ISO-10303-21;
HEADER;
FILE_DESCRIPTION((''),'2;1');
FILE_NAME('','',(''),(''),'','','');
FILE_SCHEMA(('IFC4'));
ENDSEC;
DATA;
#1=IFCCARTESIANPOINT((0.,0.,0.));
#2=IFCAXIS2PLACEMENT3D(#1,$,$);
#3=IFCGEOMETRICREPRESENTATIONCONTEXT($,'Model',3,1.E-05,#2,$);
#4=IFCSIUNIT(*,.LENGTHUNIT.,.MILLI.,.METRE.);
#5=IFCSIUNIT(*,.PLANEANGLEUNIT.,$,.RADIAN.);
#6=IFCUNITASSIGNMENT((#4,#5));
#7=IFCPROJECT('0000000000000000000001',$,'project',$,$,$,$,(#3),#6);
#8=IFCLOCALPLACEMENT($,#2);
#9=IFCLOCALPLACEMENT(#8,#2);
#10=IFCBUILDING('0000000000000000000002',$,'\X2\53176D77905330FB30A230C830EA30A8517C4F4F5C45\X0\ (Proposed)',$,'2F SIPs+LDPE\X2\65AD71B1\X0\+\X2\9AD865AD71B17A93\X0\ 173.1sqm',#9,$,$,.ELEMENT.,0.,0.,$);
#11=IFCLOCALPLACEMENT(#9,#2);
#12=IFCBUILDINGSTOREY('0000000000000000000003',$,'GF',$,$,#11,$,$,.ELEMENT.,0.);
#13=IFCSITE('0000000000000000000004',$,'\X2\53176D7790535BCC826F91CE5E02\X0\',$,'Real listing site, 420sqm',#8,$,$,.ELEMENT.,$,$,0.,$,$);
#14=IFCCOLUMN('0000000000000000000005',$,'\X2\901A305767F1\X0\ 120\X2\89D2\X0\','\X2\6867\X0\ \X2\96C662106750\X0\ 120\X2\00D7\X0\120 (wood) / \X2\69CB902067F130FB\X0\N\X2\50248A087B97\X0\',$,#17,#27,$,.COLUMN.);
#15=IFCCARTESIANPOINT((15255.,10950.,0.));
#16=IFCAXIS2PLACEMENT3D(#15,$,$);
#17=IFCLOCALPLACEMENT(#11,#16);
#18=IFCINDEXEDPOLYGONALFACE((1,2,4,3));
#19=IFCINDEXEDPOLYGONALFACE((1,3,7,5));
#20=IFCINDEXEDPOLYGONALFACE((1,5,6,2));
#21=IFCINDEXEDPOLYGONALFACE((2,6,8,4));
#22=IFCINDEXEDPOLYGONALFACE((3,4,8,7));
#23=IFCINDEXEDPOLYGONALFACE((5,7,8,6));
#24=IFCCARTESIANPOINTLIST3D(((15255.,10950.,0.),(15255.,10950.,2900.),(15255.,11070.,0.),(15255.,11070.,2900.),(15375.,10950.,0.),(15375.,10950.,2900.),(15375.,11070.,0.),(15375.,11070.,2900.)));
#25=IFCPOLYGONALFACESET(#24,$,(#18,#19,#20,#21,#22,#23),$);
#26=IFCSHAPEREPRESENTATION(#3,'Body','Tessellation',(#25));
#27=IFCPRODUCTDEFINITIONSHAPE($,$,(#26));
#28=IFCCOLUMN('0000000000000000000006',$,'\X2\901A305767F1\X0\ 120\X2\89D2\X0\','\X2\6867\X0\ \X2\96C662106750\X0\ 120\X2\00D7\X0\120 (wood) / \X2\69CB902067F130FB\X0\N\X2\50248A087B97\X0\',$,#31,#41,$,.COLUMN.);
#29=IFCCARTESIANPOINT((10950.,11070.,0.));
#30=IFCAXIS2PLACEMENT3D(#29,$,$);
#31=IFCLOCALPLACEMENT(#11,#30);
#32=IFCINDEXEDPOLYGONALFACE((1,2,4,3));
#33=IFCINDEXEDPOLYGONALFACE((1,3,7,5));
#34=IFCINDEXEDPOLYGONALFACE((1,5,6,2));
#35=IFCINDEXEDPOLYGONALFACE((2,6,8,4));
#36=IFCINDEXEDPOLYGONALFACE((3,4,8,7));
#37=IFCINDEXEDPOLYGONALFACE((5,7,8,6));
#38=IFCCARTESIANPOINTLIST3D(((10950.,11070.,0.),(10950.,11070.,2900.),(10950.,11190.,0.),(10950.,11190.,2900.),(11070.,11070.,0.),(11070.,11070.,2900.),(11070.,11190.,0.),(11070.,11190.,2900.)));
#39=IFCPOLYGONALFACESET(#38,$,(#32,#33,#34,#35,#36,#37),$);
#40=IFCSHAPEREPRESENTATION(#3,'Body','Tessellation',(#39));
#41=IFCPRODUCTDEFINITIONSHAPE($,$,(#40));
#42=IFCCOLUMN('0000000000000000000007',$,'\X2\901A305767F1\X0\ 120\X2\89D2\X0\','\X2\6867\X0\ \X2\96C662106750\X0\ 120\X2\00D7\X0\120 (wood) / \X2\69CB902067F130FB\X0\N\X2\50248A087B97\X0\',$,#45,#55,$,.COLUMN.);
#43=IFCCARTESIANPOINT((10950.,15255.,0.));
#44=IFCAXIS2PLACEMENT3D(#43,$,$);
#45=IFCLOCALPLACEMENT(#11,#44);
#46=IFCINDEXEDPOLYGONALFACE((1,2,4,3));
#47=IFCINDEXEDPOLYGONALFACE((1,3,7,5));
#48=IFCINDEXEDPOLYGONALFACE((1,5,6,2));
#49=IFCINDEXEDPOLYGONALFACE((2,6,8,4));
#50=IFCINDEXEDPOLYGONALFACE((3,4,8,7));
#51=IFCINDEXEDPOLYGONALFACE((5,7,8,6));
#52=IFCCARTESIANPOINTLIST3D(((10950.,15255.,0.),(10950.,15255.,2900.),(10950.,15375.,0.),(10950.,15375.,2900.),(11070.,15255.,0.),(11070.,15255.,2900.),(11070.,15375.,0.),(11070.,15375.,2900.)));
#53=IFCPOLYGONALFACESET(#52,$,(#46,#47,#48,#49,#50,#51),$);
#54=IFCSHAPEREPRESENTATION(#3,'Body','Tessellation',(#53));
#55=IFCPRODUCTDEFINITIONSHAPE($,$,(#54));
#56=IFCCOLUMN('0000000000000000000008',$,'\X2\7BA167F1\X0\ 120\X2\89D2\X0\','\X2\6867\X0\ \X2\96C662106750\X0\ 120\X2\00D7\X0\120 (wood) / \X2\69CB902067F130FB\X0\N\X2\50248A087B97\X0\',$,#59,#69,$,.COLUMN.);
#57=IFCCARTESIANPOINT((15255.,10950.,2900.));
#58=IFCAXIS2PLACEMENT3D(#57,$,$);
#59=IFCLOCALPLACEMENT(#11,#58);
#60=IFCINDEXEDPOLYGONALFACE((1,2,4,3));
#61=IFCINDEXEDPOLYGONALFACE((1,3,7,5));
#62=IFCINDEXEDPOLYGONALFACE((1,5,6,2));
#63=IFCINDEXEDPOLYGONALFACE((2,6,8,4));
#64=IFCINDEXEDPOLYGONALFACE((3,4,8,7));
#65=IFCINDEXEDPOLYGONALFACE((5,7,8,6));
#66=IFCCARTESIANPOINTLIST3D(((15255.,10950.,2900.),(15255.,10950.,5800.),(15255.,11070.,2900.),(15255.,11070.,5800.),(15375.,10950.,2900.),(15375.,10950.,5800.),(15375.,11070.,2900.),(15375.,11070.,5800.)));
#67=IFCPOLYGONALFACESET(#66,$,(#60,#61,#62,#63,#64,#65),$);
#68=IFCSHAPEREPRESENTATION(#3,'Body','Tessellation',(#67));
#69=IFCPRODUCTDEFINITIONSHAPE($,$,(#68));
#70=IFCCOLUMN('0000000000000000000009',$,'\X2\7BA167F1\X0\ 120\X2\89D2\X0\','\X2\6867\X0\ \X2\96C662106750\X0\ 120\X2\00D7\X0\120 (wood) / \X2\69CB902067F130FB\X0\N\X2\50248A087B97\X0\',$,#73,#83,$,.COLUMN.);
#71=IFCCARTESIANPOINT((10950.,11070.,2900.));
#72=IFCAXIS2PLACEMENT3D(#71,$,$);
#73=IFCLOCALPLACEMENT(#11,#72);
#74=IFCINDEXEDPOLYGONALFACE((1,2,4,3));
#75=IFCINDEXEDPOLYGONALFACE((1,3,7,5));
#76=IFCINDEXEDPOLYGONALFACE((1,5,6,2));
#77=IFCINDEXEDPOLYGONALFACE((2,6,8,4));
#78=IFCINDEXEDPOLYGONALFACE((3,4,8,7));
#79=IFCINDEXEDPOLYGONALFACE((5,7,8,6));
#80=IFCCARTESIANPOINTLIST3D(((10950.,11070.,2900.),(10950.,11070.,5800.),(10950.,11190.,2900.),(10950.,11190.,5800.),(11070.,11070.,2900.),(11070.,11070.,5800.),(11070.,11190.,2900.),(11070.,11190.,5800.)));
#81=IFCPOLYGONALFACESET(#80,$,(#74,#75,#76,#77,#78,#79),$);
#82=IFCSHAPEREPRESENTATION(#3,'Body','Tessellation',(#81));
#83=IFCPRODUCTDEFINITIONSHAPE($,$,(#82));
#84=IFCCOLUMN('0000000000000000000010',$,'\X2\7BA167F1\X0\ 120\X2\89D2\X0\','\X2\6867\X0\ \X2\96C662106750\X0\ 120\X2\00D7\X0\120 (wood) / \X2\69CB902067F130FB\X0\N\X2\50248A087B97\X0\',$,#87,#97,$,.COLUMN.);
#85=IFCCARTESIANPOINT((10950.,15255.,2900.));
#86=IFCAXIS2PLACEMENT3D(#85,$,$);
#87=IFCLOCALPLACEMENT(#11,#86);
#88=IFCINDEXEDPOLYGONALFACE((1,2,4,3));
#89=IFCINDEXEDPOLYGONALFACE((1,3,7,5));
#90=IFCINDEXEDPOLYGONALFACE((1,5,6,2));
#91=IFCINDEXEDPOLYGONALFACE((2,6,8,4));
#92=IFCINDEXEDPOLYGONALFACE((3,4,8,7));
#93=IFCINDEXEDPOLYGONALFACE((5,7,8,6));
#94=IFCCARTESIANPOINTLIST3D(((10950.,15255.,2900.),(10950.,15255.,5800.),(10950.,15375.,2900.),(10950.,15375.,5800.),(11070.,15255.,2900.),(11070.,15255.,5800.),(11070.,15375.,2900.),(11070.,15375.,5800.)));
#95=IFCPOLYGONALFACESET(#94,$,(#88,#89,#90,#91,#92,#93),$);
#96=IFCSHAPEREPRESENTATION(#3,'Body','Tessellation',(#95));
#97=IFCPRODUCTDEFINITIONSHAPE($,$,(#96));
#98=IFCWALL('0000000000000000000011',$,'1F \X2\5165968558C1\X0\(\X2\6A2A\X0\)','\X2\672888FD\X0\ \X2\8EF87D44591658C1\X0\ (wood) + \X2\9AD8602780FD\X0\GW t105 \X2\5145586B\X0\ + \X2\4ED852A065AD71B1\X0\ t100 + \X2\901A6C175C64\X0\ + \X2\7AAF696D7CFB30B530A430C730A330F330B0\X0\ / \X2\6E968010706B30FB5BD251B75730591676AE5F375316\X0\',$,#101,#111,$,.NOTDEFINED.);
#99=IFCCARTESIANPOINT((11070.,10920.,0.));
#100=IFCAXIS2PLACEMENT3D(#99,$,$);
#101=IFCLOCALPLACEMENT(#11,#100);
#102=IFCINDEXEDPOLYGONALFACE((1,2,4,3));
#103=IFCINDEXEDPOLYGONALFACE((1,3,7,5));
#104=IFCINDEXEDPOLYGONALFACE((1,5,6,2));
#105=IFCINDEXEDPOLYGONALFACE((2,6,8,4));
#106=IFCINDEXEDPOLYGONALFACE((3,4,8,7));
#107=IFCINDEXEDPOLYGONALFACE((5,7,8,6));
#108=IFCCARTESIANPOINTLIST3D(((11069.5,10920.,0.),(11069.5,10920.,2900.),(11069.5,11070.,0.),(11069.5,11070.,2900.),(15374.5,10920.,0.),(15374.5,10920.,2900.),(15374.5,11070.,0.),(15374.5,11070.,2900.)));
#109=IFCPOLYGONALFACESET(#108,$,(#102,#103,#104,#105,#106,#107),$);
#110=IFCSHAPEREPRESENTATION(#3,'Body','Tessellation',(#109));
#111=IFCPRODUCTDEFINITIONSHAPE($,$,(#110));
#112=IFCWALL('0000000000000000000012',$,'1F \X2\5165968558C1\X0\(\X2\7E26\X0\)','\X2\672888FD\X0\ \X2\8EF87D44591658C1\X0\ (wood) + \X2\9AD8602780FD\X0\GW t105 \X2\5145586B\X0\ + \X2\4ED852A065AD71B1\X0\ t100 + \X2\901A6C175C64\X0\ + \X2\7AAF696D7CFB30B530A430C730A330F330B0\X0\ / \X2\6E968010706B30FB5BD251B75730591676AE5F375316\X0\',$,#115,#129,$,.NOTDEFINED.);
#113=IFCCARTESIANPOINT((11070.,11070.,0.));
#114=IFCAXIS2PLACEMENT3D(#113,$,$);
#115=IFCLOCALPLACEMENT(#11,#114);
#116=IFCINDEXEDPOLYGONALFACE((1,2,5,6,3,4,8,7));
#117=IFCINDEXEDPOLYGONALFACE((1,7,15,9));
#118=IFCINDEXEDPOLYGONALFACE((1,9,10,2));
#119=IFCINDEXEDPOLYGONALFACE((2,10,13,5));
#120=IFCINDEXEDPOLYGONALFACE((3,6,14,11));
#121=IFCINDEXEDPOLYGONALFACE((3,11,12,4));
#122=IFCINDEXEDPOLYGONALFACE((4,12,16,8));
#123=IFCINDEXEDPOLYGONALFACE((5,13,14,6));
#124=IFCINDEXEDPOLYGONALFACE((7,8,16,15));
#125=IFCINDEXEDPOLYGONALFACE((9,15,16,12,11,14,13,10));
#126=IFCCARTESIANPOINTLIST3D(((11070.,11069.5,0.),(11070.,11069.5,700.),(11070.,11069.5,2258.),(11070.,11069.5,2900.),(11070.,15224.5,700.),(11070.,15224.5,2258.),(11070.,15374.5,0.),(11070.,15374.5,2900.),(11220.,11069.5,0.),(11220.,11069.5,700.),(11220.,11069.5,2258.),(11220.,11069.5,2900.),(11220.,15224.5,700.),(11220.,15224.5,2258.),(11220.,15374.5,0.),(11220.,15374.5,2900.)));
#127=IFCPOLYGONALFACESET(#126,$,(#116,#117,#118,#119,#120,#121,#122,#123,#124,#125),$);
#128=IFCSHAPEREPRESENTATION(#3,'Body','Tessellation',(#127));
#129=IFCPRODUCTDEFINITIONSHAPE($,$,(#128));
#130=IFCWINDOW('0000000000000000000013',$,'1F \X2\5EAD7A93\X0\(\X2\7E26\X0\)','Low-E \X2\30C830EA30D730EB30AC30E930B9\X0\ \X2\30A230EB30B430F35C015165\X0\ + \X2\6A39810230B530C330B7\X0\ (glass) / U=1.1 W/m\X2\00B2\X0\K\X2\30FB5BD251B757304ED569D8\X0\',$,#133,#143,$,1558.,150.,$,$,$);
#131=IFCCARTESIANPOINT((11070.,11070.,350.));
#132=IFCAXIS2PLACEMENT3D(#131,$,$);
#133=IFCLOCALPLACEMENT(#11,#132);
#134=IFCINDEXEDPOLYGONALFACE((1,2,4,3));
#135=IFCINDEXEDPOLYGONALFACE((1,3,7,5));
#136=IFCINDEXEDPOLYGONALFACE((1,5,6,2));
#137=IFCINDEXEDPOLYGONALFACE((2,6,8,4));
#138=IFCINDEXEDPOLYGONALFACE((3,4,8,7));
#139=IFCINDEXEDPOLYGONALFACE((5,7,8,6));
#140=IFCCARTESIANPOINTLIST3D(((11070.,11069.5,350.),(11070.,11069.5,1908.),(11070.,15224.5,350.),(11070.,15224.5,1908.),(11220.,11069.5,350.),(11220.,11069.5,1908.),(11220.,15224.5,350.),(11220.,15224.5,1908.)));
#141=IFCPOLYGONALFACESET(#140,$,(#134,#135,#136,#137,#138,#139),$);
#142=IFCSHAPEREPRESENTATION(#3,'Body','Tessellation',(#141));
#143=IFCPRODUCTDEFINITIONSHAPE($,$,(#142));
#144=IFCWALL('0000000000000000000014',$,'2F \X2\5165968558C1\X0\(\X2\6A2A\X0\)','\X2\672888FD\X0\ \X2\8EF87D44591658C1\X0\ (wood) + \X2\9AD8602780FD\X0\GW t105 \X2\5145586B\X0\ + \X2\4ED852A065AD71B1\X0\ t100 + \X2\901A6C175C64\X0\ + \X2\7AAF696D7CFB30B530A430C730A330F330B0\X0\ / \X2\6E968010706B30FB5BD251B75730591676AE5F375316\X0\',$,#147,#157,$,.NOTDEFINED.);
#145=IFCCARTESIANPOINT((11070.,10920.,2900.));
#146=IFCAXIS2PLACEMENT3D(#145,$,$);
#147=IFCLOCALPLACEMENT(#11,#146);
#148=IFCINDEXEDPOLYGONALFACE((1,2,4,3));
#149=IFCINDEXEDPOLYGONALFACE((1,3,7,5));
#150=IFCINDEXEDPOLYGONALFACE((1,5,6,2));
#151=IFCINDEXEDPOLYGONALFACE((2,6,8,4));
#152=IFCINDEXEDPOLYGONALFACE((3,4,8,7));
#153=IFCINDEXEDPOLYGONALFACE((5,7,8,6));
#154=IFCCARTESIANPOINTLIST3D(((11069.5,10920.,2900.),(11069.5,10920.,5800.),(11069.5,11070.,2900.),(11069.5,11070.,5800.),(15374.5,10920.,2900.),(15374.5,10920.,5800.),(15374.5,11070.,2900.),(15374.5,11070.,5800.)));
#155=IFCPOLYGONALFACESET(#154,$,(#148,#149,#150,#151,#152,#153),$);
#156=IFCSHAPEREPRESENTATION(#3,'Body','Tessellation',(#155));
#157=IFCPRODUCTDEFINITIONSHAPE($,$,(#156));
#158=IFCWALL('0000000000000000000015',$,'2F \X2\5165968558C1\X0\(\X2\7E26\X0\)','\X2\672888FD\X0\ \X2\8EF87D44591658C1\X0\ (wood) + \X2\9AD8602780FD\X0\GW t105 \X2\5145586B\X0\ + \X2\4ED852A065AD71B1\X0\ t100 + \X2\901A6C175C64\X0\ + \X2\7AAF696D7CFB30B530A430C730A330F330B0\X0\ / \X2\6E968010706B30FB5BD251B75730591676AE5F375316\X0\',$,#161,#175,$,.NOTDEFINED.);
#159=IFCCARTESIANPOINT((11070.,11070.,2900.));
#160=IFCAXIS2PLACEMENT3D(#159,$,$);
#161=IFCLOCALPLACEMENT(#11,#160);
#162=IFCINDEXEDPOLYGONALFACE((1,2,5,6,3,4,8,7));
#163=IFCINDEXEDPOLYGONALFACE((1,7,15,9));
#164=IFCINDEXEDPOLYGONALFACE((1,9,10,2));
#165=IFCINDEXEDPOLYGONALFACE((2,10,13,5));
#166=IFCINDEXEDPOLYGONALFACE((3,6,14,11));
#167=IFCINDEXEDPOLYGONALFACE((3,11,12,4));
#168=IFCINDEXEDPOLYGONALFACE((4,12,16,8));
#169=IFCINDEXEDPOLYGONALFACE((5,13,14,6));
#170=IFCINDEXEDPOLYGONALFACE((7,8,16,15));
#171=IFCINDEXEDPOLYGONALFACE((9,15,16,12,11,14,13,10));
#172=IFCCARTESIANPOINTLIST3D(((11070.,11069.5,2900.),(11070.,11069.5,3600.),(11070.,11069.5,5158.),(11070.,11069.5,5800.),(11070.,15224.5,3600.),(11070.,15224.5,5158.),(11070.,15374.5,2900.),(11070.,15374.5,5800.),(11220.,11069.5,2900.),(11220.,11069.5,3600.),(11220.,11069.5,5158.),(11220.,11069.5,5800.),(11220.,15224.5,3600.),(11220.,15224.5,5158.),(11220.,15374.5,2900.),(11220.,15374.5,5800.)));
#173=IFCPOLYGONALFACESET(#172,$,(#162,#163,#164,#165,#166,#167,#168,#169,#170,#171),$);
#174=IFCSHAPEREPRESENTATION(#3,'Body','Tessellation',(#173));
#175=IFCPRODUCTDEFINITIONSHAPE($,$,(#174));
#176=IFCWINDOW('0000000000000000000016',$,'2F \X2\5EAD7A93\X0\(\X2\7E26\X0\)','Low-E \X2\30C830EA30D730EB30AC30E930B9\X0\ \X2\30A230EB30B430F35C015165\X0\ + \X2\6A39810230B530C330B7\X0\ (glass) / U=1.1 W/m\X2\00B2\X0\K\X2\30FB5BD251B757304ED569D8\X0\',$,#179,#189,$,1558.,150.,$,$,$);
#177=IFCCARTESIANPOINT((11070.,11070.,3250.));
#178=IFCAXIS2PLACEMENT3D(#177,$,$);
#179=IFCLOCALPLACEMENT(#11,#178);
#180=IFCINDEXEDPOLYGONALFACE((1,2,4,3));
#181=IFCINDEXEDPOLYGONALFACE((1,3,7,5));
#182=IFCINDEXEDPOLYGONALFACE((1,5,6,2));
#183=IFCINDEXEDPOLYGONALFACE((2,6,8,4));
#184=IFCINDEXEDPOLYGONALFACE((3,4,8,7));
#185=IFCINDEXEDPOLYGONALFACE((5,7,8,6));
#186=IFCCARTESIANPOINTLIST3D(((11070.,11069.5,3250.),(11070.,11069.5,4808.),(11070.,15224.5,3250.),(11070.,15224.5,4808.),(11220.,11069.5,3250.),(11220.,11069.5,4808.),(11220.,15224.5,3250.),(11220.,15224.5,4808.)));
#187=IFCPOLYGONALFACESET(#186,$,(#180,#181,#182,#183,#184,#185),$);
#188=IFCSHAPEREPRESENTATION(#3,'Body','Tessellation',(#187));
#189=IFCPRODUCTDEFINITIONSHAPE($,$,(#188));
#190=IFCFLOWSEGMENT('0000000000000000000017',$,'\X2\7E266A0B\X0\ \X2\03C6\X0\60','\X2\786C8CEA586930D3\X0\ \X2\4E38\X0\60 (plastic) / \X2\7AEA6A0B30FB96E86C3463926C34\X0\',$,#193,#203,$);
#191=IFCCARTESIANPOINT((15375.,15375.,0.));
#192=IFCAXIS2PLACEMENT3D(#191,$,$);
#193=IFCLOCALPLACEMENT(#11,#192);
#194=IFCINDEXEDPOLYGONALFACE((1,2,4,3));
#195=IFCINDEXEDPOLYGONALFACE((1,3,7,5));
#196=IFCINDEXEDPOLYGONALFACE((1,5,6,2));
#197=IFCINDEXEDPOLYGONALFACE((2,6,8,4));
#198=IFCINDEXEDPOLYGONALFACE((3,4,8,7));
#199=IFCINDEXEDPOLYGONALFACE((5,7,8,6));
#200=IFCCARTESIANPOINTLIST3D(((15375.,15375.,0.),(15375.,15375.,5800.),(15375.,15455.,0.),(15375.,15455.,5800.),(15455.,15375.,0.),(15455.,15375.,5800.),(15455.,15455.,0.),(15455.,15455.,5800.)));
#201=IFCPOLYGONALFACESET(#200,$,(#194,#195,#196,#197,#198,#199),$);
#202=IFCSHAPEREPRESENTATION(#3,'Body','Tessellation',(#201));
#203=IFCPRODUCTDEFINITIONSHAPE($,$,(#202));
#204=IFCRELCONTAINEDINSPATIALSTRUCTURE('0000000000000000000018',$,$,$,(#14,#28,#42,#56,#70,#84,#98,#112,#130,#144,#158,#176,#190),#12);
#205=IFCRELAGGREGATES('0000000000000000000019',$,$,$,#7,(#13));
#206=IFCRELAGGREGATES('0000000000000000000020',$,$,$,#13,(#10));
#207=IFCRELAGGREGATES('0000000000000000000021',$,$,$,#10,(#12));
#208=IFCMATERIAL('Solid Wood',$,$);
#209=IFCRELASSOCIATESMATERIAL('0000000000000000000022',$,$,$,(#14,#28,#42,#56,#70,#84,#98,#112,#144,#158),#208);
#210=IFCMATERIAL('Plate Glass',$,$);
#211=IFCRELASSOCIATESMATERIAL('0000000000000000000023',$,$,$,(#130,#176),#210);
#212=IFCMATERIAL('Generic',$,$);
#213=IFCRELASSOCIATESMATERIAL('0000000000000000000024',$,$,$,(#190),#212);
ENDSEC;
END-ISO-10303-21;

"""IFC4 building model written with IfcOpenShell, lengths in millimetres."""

from ifc_helpers import new_model, si_unit, frame, frame_2d, origin, place, context, project, spatial, rectangle, extrude, material, element, fill, save


model = new_model("IFC4")

# Units and contexts
model_context = context("Model", 3, precision=1e-05, world=origin())
ifc_project = project(units=[si_unit("LENGTHUNIT", "METRE", prefix="MILLI"), si_unit("PLANEANGLEUNIT", "RADIAN")], contexts=[model_context])

# Site, building, storey
site_placement = place(None, origin())
site = spatial("IfcSite", under=ifc_project, at=site_placement, Name="北海道富良野市", ObjectType="Real listing site, 420sqm", CompositionType="ELEMENT", RefElevation=0.0)
building_placement = place(site_placement, origin())
building = spatial("IfcBuilding", under=site, at=building_placement, Name="北海道・アトリエ兼住居 (Proposed)", ObjectType="2F SIPs+LDPE断熱+高断熱窓 173.1sqm", CompositionType="ELEMENT", ElevationOfRefHeight=0.0, ElevationOfTerrain=0.0)
storey_placement = place(building_placement, origin())
storey = spatial("IfcBuildingStorey", under=building, at=storey_placement, Name="GF", CompositionType="ELEMENT", Elevation=0.0)

# Columns
ifc_material_1 = material(Name="Solid Wood")
column_1_placement = place(storey_placement, frame((15255.0, 10950.0, 0.0)))
element("IfcColumn", 1, at=column_1_placement, inside=storey, material=ifc_material_1, Name="通し柱 120角", Description="桧 集成材 120×120 (wood) / 構造柱・N値計算", PredefinedType="COLUMN", context=model_context, shape_type="SweptSolid", body=[
    extrude(rectangle(XDim=120.0, YDim=120.0, at=frame_2d((60.0, 60.0))), frame((15255.0, 10950.0, 0.0)), (0.0, 0.0, 1.0), 2900.0),
])
column_2_placement = place(storey_placement, frame((10950.0, 11070.0, 0.0)))
element("IfcColumn", 2, at=column_2_placement, inside=storey, material=ifc_material_1, Name="通し柱 120角", Description="桧 集成材 120×120 (wood) / 構造柱・N値計算", PredefinedType="COLUMN", context=model_context, shape_type="SweptSolid", body=[
    extrude(rectangle(XDim=120.0, YDim=120.0, at=frame_2d((60.0, 60.0))), frame((10950.0, 11070.0, 0.0)), (0.0, 0.0, 1.0), 2900.0),
])
column_3_placement = place(storey_placement, frame((10950.0, 15255.0, 0.0)))
element("IfcColumn", 3, at=column_3_placement, inside=storey, material=ifc_material_1, Name="通し柱 120角", Description="桧 集成材 120×120 (wood) / 構造柱・N値計算", PredefinedType="COLUMN", context=model_context, shape_type="SweptSolid", body=[
    extrude(rectangle(XDim=120.0, YDim=120.0, at=frame_2d((60.0, 60.0))), frame((10950.0, 15255.0, 0.0)), (0.0, 0.0, 1.0), 2900.0),
])
column_4_placement = place(storey_placement, frame((15255.0, 10950.0, 2900.0)))
element("IfcColumn", 4, at=column_4_placement, inside=storey, material=ifc_material_1, Name="管柱 120角", Description="桧 集成材 120×120 (wood) / 構造柱・N値計算", PredefinedType="COLUMN", context=model_context, shape_type="SweptSolid", body=[
    extrude(rectangle(XDim=120.0, YDim=120.0, at=frame_2d((60.0, 60.0))), frame((15255.0, 10950.0, 2900.0)), (0.0, 0.0, 1.0), 2900.0),
])
column_5_placement = place(storey_placement, frame((10950.0, 11070.0, 2900.0)))
element("IfcColumn", 5, at=column_5_placement, inside=storey, material=ifc_material_1, Name="管柱 120角", Description="桧 集成材 120×120 (wood) / 構造柱・N値計算", PredefinedType="COLUMN", context=model_context, shape_type="SweptSolid", body=[
    extrude(rectangle(XDim=120.0, YDim=120.0, at=frame_2d((60.0, 60.0))), frame((10950.0, 11070.0, 2900.0)), (0.0, 0.0, 1.0), 2900.0),
])
column_6_placement = place(storey_placement, frame((10950.0, 15255.0, 2900.0)))
element("IfcColumn", 6, at=column_6_placement, inside=storey, material=ifc_material_1, Name="管柱 120角", Description="桧 集成材 120×120 (wood) / 構造柱・N値計算", PredefinedType="COLUMN", context=model_context, shape_type="SweptSolid", body=[
    extrude(rectangle(XDim=120.0, YDim=120.0, at=frame_2d((60.0, 60.0))), frame((10950.0, 15255.0, 2900.0)), (0.0, 0.0, 1.0), 2900.0),
])

# Wall
wall_1_placement = place(storey_placement, frame((11070.0, 10920.0, 0.0)))
element("IfcWall", 7, at=wall_1_placement, inside=storey, material=ifc_material_1, Name="1F 入隅壁(横)", Description="木製 軸組外壁 (wood) + 高性能GW t105 充填 + 付加断熱 t100 + 通気層 + 窯業系サイディング / 準耐火・寒冷地外皮強化", PredefinedType="NOTDEFINED", context=model_context, shape_type="SweptSolid", body=[
    extrude(rectangle(XDim=4305.0, YDim=150.0, at=frame_2d((2152.0, 75.0))), frame((11070.0, 10920.0, 0.0)), (0.0, 0.0, 1.0), 2900.0),
])

# Wall, opening, window
wall_2_placement = place(storey_placement, frame((11070.0, 11070.0, 0.0)))
wall_2 = element("IfcWall", 8, at=wall_2_placement, inside=storey, material=ifc_material_1, Name="1F 入隅壁(縦)", Description="木製 軸組外壁 (wood) + 高性能GW t105 充填 + 付加断熱 t100 + 通気層 + 窯業系サイディング / 準耐火・寒冷地外皮強化", PredefinedType="NOTDEFINED", context=model_context, shape_type="SweptSolid", body=[
    extrude(rectangle(XDim=150.0, YDim=4305.0, at=frame_2d((75.0, 2152.0))), frame((11070.0, 11070.0, 0.0)), (0.0, 0.0, 1.0), 2900.0),
])
opening_1_placement = place(storey_placement, frame((11070.0, 11070.0, 350.0)))
opening_1 = element("IfcOpeningElement", 9, at=opening_1_placement, cuts=wall_2, PredefinedType="NOTDEFINED", context=model_context, shape_type="SweptSolid", body=[
    extrude(rectangle(XDim=150.0, YDim=4155.0, at=frame_2d((75.0, 2077.0))), frame((11070.0, 11070.0, 350.0)), (0.0, 0.0, 1.0), 1558.0),
])
ifc_material_2 = material(Name="Plate Glass")
window_1_placement = place(storey_placement, frame((11070.0, 11070.0, 350.0)))
window_1 = element("IfcWindow", 10, at=window_1_placement, inside=storey, material=ifc_material_2, Name="1F 庭窓(縦)", Description="Low-E トリプルガラス アルゴン封入 + 樹脂サッシ (glass) / U=1.1 W/m²K・寒冷地仕様", OverallHeight=1558.0, OverallWidth=150.0, context=model_context, shape_type="SweptSolid", body=[
    extrude(rectangle(XDim=150.0, YDim=4155.0, at=frame_2d((75.0, 2077.0))), frame((11070.0, 11070.0, 350.0)), (0.0, 0.0, 1.0), 1558.0),
])
fill(opening_1, window_1)

# Wall
wall_3_placement = place(storey_placement, frame((11070.0, 10920.0, 2900.0)))
element("IfcWall", 11, at=wall_3_placement, inside=storey, material=ifc_material_1, Name="2F 入隅壁(横)", Description="木製 軸組外壁 (wood) + 高性能GW t105 充填 + 付加断熱 t100 + 通気層 + 窯業系サイディング / 準耐火・寒冷地外皮強化", PredefinedType="NOTDEFINED", context=model_context, shape_type="SweptSolid", body=[
    extrude(rectangle(XDim=4305.0, YDim=150.0, at=frame_2d((2152.0, 75.0))), frame((11070.0, 10920.0, 2900.0)), (0.0, 0.0, 1.0), 2900.0),
])

# Wall, opening, window
wall_4_placement = place(storey_placement, frame((11070.0, 11070.0, 2900.0)))
wall_4 = element("IfcWall", 12, at=wall_4_placement, inside=storey, material=ifc_material_1, Name="2F 入隅壁(縦)", Description="木製 軸組外壁 (wood) + 高性能GW t105 充填 + 付加断熱 t100 + 通気層 + 窯業系サイディング / 準耐火・寒冷地外皮強化", PredefinedType="NOTDEFINED", context=model_context, shape_type="SweptSolid", body=[
    extrude(rectangle(XDim=150.0, YDim=4305.0, at=frame_2d((75.0, 2152.0))), frame((11070.0, 11070.0, 2900.0)), (0.0, 0.0, 1.0), 2900.0),
])
opening_2_placement = place(storey_placement, frame((11070.0, 11070.0, 3250.0)))
opening_2 = element("IfcOpeningElement", 13, at=opening_2_placement, cuts=wall_4, PredefinedType="NOTDEFINED", context=model_context, shape_type="SweptSolid", body=[
    extrude(rectangle(XDim=150.0, YDim=4155.0, at=frame_2d((75.0, 2077.0))), frame((11070.0, 11070.0, 3250.0)), (0.0, 0.0, 1.0), 1558.0),
])
window_2_placement = place(storey_placement, frame((11070.0, 11070.0, 3250.0)))
window_2 = element("IfcWindow", 14, at=window_2_placement, inside=storey, material=ifc_material_2, Name="2F 庭窓(縦)", Description="Low-E トリプルガラス アルゴン封入 + 樹脂サッシ (glass) / U=1.1 W/m²K・寒冷地仕様", OverallHeight=1558.0, OverallWidth=150.0, context=model_context, shape_type="SweptSolid", body=[
    extrude(rectangle(XDim=150.0, YDim=4155.0, at=frame_2d((75.0, 2077.0))), frame((11070.0, 11070.0, 3250.0)), (0.0, 0.0, 1.0), 1558.0),
])
fill(opening_2, window_2)

# Flow segment
ifc_material_3 = material(Name="Generic")
flow_segment_placement = place(storey_placement, frame((15375.0, 15375.0, 0.0)))
element("IfcFlowSegment", 15, at=flow_segment_placement, inside=storey, material=ifc_material_3, Name="縦樋 φ60", Description="硬質塩ビ 丸60 (plastic) / 竪樋・雨水排水", context=model_context, shape_type="SweptSolid", body=[
    extrude(rectangle(XDim=80.0, YDim=80.0, at=frame_2d((40.0, 40.0))), frame((15375.0, 15375.0, 0.0)), (0.0, 0.0, 1.0), 5800.0),
])

save(model, "model.ifc")
